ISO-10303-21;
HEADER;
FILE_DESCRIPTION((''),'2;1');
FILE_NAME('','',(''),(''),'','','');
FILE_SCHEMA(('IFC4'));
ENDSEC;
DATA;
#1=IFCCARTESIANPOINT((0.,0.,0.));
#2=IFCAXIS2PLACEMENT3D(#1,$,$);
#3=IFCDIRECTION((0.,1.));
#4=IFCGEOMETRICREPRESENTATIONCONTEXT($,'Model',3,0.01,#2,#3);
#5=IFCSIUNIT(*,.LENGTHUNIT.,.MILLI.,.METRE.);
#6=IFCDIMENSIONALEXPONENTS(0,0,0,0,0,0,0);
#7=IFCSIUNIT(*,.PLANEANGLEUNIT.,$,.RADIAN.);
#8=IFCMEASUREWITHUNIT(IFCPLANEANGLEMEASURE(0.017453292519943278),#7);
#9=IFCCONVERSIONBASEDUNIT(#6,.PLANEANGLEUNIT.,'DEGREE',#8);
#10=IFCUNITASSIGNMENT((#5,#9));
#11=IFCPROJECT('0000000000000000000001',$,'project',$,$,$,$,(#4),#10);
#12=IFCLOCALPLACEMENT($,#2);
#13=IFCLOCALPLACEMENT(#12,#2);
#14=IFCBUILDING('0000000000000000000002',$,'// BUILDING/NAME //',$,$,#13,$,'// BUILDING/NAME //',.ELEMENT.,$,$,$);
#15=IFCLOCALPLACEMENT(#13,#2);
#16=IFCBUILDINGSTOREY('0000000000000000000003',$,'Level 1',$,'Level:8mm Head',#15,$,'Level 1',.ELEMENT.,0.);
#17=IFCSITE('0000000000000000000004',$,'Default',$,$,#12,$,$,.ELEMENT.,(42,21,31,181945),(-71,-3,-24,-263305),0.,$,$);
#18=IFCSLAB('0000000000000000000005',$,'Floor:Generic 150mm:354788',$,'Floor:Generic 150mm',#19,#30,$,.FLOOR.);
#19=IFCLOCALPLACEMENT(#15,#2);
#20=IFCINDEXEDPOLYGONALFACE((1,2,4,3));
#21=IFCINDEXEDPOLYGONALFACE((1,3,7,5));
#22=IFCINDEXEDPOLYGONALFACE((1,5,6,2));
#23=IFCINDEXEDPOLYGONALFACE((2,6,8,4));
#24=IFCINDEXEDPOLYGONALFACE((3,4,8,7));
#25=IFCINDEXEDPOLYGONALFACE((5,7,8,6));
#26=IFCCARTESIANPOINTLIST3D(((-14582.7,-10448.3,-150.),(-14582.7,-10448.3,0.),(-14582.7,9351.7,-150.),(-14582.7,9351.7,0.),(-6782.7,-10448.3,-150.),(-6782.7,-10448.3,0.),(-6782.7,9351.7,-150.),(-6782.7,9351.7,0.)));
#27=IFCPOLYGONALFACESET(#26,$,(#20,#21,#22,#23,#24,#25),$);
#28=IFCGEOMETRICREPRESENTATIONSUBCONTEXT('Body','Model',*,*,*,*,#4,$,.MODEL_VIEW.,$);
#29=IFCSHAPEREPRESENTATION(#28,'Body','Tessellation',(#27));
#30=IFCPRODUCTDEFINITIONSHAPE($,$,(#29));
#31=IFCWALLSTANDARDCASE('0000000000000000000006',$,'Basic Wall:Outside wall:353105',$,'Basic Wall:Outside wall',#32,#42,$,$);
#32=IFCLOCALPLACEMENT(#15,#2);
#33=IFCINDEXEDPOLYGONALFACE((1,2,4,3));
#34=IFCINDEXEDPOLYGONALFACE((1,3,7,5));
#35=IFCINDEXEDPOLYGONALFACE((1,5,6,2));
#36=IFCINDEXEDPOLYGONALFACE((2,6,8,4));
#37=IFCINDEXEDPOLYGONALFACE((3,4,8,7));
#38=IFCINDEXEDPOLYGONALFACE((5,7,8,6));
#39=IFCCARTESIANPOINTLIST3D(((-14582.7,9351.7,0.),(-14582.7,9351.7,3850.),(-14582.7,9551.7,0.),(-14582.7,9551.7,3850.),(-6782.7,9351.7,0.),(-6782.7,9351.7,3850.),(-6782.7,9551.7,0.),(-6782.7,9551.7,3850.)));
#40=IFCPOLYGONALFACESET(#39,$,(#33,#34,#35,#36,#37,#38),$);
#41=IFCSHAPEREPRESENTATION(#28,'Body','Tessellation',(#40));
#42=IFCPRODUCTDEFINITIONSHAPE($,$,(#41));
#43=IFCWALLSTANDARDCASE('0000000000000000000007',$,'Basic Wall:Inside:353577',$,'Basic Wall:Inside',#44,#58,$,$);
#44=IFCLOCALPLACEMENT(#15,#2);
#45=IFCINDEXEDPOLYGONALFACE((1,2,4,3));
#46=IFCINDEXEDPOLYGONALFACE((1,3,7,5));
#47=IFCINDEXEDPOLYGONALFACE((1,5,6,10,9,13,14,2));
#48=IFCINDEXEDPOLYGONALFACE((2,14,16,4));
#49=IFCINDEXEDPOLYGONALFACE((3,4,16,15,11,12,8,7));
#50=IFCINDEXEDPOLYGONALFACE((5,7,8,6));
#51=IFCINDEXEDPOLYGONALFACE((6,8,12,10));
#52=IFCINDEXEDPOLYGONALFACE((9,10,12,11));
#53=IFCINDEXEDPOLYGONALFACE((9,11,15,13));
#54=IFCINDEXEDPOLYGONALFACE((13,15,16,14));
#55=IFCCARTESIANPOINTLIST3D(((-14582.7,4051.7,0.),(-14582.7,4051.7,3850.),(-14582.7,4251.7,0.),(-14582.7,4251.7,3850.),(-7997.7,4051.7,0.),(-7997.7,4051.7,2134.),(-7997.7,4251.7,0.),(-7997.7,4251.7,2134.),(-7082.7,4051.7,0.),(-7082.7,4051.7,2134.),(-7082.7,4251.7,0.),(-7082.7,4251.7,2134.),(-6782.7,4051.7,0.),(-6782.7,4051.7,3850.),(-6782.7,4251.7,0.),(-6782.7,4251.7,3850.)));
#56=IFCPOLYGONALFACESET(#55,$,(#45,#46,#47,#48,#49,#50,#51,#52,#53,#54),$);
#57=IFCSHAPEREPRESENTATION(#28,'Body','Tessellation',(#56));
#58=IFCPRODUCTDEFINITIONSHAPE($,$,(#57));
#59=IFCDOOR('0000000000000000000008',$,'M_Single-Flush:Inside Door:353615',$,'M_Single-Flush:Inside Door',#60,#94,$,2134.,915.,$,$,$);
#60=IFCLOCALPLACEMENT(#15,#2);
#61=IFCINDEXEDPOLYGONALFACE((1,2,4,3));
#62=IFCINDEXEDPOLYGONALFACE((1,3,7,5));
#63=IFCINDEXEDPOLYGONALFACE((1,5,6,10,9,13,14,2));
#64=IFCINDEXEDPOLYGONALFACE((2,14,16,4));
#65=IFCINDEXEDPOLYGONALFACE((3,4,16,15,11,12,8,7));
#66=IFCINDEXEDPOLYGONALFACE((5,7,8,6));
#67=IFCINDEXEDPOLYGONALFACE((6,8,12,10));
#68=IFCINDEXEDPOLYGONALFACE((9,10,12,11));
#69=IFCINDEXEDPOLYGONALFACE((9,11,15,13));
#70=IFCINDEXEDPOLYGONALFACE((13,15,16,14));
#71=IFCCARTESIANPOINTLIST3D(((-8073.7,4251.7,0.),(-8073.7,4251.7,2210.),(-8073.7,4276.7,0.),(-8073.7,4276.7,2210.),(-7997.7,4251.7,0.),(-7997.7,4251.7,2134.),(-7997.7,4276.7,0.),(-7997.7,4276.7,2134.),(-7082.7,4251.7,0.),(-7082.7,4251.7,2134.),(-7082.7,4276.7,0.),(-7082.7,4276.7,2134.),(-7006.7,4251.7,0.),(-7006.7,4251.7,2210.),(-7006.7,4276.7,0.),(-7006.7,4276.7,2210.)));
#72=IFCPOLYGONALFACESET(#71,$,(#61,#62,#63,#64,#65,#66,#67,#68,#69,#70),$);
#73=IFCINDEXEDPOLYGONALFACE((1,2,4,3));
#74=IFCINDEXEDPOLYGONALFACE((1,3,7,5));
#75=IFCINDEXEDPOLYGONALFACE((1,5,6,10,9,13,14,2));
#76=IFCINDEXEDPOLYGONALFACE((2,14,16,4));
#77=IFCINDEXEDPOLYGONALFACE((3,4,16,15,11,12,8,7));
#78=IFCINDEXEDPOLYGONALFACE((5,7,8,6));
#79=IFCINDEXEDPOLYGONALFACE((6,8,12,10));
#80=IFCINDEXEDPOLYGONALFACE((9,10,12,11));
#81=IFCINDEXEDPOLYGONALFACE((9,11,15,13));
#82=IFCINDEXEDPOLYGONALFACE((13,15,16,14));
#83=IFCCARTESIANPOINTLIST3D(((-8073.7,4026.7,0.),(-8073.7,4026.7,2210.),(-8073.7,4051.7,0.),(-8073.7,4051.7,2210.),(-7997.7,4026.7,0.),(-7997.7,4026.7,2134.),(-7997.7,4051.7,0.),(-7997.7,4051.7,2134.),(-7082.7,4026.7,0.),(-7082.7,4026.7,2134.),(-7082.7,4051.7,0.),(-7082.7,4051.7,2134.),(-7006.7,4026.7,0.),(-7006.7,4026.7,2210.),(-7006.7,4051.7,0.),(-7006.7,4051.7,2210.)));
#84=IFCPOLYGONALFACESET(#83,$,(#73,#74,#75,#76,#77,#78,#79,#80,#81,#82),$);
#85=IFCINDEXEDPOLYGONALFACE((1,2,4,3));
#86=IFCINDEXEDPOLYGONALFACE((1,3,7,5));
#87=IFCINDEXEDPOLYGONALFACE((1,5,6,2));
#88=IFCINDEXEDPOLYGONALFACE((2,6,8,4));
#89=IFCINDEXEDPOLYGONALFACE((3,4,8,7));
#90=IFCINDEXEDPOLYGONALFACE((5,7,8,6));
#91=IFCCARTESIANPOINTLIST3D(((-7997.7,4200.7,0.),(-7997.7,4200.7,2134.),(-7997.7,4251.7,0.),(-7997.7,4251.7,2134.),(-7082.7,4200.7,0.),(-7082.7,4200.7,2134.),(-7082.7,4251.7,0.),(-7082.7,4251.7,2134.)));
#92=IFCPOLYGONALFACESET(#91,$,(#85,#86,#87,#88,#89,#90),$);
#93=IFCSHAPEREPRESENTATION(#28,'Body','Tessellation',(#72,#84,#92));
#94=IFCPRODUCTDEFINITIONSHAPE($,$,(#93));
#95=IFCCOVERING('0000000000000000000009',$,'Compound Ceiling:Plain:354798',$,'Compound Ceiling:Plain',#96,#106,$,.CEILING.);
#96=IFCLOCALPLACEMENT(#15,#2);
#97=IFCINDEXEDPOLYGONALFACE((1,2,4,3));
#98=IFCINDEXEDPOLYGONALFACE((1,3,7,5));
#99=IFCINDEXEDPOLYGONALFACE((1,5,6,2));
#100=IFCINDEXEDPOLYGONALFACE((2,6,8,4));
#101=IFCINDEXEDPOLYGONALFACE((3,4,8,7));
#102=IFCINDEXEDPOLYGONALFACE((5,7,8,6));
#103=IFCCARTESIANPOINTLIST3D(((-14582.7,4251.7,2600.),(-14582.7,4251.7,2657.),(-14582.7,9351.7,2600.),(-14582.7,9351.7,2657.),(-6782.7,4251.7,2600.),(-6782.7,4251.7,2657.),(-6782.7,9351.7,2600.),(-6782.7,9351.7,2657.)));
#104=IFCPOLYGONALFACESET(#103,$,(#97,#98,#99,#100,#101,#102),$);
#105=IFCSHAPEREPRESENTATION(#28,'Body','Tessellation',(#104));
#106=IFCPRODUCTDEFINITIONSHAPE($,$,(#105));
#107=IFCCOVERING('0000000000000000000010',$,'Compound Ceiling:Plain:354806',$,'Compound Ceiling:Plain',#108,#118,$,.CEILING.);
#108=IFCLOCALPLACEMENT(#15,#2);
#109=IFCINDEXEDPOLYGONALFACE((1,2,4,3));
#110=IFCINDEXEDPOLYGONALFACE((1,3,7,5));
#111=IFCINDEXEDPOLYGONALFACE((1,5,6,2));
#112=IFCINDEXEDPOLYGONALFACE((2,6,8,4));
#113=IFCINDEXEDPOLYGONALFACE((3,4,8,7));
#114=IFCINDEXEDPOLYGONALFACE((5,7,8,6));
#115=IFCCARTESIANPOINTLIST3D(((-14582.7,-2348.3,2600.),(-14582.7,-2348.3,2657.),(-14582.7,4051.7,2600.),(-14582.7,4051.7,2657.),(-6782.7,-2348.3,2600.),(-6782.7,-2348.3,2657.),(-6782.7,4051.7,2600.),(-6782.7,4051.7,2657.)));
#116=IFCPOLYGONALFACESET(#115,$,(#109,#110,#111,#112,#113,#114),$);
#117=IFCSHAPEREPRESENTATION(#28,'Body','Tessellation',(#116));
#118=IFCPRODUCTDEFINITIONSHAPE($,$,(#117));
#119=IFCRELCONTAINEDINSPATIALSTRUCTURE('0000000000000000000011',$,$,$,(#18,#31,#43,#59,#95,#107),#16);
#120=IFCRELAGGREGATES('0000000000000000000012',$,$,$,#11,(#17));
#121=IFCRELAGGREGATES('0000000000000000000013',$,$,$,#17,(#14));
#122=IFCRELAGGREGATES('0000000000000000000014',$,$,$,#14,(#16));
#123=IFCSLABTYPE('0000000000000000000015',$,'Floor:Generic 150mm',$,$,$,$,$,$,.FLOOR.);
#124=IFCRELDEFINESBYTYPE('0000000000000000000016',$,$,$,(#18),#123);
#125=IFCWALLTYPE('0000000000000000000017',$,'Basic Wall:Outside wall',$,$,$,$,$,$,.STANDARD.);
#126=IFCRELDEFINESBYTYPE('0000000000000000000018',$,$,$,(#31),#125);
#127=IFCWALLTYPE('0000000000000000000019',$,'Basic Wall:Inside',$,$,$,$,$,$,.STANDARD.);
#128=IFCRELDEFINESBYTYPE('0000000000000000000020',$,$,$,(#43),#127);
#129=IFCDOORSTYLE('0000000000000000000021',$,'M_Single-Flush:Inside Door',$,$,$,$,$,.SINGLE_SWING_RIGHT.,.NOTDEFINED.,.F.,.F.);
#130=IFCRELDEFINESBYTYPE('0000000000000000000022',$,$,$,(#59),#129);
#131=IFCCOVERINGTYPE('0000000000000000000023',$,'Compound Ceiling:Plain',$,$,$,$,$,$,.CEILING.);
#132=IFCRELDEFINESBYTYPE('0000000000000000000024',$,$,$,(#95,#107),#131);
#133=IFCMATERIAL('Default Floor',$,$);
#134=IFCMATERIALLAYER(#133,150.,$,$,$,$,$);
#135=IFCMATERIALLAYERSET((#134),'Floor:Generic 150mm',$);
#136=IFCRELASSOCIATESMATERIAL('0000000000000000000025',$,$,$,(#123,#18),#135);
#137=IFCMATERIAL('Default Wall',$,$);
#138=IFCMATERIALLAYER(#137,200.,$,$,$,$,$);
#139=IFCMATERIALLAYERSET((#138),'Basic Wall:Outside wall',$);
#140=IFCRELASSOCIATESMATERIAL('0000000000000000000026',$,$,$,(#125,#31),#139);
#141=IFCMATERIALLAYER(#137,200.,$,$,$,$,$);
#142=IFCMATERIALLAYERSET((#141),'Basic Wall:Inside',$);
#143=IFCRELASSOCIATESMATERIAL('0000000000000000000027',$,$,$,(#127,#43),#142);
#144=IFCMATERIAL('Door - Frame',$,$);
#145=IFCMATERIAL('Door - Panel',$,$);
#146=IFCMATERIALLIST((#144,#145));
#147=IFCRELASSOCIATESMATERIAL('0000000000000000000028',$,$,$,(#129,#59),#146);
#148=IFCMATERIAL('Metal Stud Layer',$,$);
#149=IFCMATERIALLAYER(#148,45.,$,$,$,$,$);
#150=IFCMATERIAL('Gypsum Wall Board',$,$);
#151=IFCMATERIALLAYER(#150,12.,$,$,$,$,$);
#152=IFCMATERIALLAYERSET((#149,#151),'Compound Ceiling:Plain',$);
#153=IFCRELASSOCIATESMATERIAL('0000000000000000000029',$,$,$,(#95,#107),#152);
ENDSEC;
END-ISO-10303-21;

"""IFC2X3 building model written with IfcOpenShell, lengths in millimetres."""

from ifc_helpers import new_model, entity, si_unit, converted_unit, direction, frame, frame_2d, origin, place, context, subcontext, project, spatial, polyline, rectangle, outline, extrude, clip, bounded_halfspace, source, transform, mapped, material, material_list, layer, layer_set, layer_usage, type_object, type_shapes, element, fill, save


model = new_model("IFC2X3")

# Units and contexts
model_context = context("Model", 3, precision=0.01, world=origin(), true_north=direction((0.0, 1.0)))
body_context = subcontext(model_context, "Body", "Model", "MODEL_VIEW")
ifc_project = project(units=[si_unit("LENGTHUNIT", "METRE", prefix="MILLI"), converted_unit("PLANEANGLEUNIT", "DEGREE", entity("IfcPlaneAngleMeasure", 0.017453292519943278), si_unit("PLANEANGLEUNIT", "RADIAN"), dimensions=[0, 0, 0, 0, 0, 0, 0])], contexts=[model_context])

# Site, building, storey
site_placement = place(None, origin())
site = spatial("IfcSite", under=ifc_project, at=site_placement, Name="Default", CompositionType="ELEMENT", RefLatitude=(42, 21, 31, 181945), RefLongitude=(-71, -3, -24, -263305), RefElevation=0.0)
building_placement = place(site_placement, origin())
building = spatial("IfcBuilding", under=site, at=building_placement, Name="// BUILDING/NAME //", LongName="// BUILDING/NAME //", CompositionType="ELEMENT")
storey_placement = place(building_placement, origin())
storey = spatial("IfcBuildingStorey", under=building, at=storey_placement, Name="Level 1", ObjectType="Level:8mm Head", LongName="Level 1", CompositionType="ELEMENT", Elevation=0.0)

# Slab
ifc_material_1 = material(Name="Default Floor")
ifc_layer_1 = layer(ifc_material_1, 150.0)
ifc_layer_set_1 = layer_set([ifc_layer_1], Name="Floor:Generic 150mm")
ifc_layer_usage_1 = layer_usage(ifc_layer_set_1, "AXIS3", "POSITIVE", 0.0)
slab_type = type_object("IfcSlabType", Name="Floor:Generic 150mm", PredefinedType="FLOOR", material=ifc_layer_set_1)
slab_placement = place(storey_placement, origin())
element("IfcSlab", 1, at=slab_placement, inside=storey, type_object=slab_type, material=ifc_layer_usage_1, Name="Floor:Generic 150mm:354788", ObjectType="Floor:Generic 150mm", PredefinedType="FLOOR", context=body_context, shape_type="SweptSolid", body=[
    extrude(rectangle(XDim=19800.0, YDim=7800.0, at=frame_2d((0.0, 0.0), x_axis=(1.0, 0.0))), frame((-10682.7, -548.3, 0.0), z_axis=(0.0, 0.0, -1.0), x_axis=(0.0, 1.0, 0.0)), (0.0, 0.0, 1.0), 150.0),
])

# Wall
ifc_material_2 = material(Name="Default Wall")
ifc_layer_2 = layer(ifc_material_2, 200.0)
ifc_layer_set_2 = layer_set([ifc_layer_2], Name="Basic Wall:Outside wall")
ifc_layer_usage_2 = layer_usage(ifc_layer_set_2, "AXIS2", "NEGATIVE", 100.0)
wall_type_1 = type_object("IfcWallType", Name="Basic Wall:Outside wall", PredefinedType="STANDARD", material=ifc_layer_set_2)
wall_1_placement = place(storey_placement, frame((-6782.7, 9451.7, 0.0), z_axis=(0.0, 0.0, 1.0), x_axis=(-1.0, 0.0, 0.0)))
element("IfcWallStandardCase", 2, at=wall_1_placement, inside=storey, type_object=wall_type_1, material=ifc_layer_usage_2, Name="Basic Wall:Outside wall:353105", ObjectType="Basic Wall:Outside wall", context=body_context, shape_type="Clipping", body=[
    clip(extrude(rectangle(XDim=7800.0, YDim=200.0, at=frame_2d((3900.0, 0.0), x_axis=(-1.0, 0.0))), origin(), (0.0, 0.0, 1.0), 3850.0), bounded_halfspace(frame((0.0, -100.0, 3850.0), z_axis=(0.0, 0.0, -1.0), x_axis=(-1.0, 0.0, 0.0)), True, frame((0.0, -100.0, 3850.0)), polyline([(0.0, 0.0), (7800.0, 0.0), (7800.0, 200.0), (0.0, 200.0), (0.0, 0.0)]))),
])

# Wall, opening, door
ifc_layer_3 = layer(ifc_material_2, 200.0)
ifc_layer_set_3 = layer_set([ifc_layer_3], Name="Basic Wall:Inside")
ifc_layer_usage_3 = layer_usage(ifc_layer_set_3, "AXIS2", "NEGATIVE", 100.0)
wall_type_2 = type_object("IfcWallType", Name="Basic Wall:Inside", PredefinedType="STANDARD", material=ifc_layer_set_3)
wall_2_placement = place(storey_placement, frame((-14582.7, 4151.7, 0.0)))
wall_2 = element("IfcWallStandardCase", 3, at=wall_2_placement, inside=storey, type_object=wall_type_2, material=ifc_layer_usage_3, Name="Basic Wall:Inside:353577", ObjectType="Basic Wall:Inside", context=body_context, shape_type="Clipping", body=[
    clip(extrude(rectangle(XDim=7800.0, YDim=200.0, at=frame_2d((3900.0, 0.0), x_axis=(-1.0, 0.0))), origin(), (0.0, 0.0, 1.0), 3850.0), bounded_halfspace(frame((0.0, -100.0, 3850.0), z_axis=(0.0, 0.0, -1.0), x_axis=(1.0, 0.0, 0.0)), True, frame((0.0, -100.0, 3850.0)), polyline([(0.0, 0.0), (7800.0, 0.0), (7800.0, 200.0), (0.0, 200.0), (0.0, 0.0)]))),
])
opening_placement = place(wall_2_placement, frame((6585.0, -100.0, 0.0)))
opening = element("IfcOpeningElement", 4, at=opening_placement, cuts=wall_2, ObjectType="Opening", context=body_context, shape_type="SweptSolid", body=[
    extrude(rectangle(XDim=915.0, YDim=2134.0, at=frame_2d((1067.0, 457.5), x_axis=(0.0, 1.0))), frame((0.0, 0.0, 0.0), z_axis=(0.0, 1.0, 0.0), x_axis=(0.0, 0.0, 1.0)), (0.0, 0.0, 1.0), 200.0),
])
ifc_material_3 = material(Name="Door - Frame")
ifc_material_4 = material(Name="Door - Panel")
ifc_material_list = material_list([ifc_material_3, ifc_material_4])
door_style = type_object("IfcDoorStyle", Name="M_Single-Flush:Inside Door", ConstructionType="NOTDEFINED", OperationType="SINGLE_SWING_RIGHT", ParameterTakesPrecedence=False, Sizeable=False, material=ifc_material_list)
shared_shape = source(origin(), body_context, "Body", "SweptSolid", [
    extrude(outline(polyline([(-533.5, -1124.0), (533.5, -1124.0), (533.5, 1086.0), (457.5, 1086.0), (457.5, -1048.0), (-457.5, -1048.0), (-457.5, 1086.0), (-533.5, 1086.0), (-533.5, -1124.0)])), frame((457.5, 200.0, 1086.0), z_axis=(0.0, 1.0, 0.0), x_axis=(1.0, 0.0, 0.0)), (0.0, 0.0, 1.0), 25.0),
    extrude(outline(polyline([(-1124.0, -533.5), (1086.0, -533.5), (1086.0, -457.5), (-1048.0, -457.5), (-1048.0, 457.5), (1086.0, 457.5), (1086.0, 533.5), (-1124.0, 533.5), (-1124.0, -533.5)])), frame((457.5, -25.0, 1086.0), z_axis=(0.0, 1.0, 0.0), x_axis=(0.0, 0.0, -1.0)), (0.0, 0.0, 1.0), 25.0),
    extrude(rectangle(XDim=51.0, YDim=915.0, at=frame_2d((0.0, 0.0), x_axis=(1.0, 0.0))), frame((457.5, 174.5, 0.0), z_axis=(0.0, 0.0, 1.0), x_axis=(0.0, 1.0, 0.0)), (0.0, 0.0, 1.0), 2134.0),
])
type_shapes(door_style, [shared_shape])
door_placement = place(opening_placement, origin())
door = element("IfcDoor", 5, at=door_placement, inside=storey, type_object=door_style, material=ifc_material_list, Name="M_Single-Flush:Inside Door:353615", ObjectType="M_Single-Flush:Inside Door", OverallHeight=2134.0, OverallWidth=915.0, context=body_context, shape_type="MappedRepresentation", body=[
    mapped(shared_shape, transform((0.0, 0.0, 0.0), scale=1.0)),
])
fill(opening, door)

# Coverings
ifc_material_5 = material(Name="Metal Stud Layer")
ifc_layer_4 = layer(ifc_material_5, 45.0)
ifc_material_6 = material(Name="Gypsum Wall Board")
ifc_layer_5 = layer(ifc_material_6, 12.0)
ifc_layer_set_4 = layer_set([ifc_layer_4, ifc_layer_5], Name="Compound Ceiling:Plain")
ifc_layer_usage_4 = layer_usage(ifc_layer_set_4, "AXIS3", "NEGATIVE", 57.0)
covering_type = type_object("IfcCoveringType", Name="Compound Ceiling:Plain", PredefinedType="CEILING")
covering_1_placement = place(storey_placement, origin())
element("IfcCovering", 6, at=covering_1_placement, inside=storey, type_object=covering_type, material=ifc_layer_usage_4, Name="Compound Ceiling:Plain:354798", ObjectType="Compound Ceiling:Plain", PredefinedType="CEILING", context=body_context, shape_type="SweptSolid", body=[
    extrude(rectangle(XDim=5100.0, YDim=7800.0, at=frame_2d((0.0, 0.0), x_axis=(1.0, 0.0))), frame((-10682.7, 6801.7, 2600.0), z_axis=(0.0, 0.0, 1.0), x_axis=(0.0, 1.0, 0.0)), (0.0, 0.0, 1.0), 57.0),
])
covering_2_placement = place(storey_placement, origin())
element("IfcCovering", 7, at=covering_2_placement, inside=storey, type_object=covering_type, material=ifc_layer_usage_4, Name="Compound Ceiling:Plain:354806", ObjectType="Compound Ceiling:Plain", PredefinedType="CEILING", context=body_context, shape_type="SweptSolid", body=[
    extrude(rectangle(XDim=6400.0, YDim=7800.0, at=frame_2d((0.0, 0.0), x_axis=(1.0, 0.0))), frame((-10682.7, 851.7, 2600.0), z_axis=(0.0, 0.0, 1.0), x_axis=(0.0, 1.0, 0.0)), (0.0, 0.0, 1.0), 57.0),
])

save(model, "model.ifc")
